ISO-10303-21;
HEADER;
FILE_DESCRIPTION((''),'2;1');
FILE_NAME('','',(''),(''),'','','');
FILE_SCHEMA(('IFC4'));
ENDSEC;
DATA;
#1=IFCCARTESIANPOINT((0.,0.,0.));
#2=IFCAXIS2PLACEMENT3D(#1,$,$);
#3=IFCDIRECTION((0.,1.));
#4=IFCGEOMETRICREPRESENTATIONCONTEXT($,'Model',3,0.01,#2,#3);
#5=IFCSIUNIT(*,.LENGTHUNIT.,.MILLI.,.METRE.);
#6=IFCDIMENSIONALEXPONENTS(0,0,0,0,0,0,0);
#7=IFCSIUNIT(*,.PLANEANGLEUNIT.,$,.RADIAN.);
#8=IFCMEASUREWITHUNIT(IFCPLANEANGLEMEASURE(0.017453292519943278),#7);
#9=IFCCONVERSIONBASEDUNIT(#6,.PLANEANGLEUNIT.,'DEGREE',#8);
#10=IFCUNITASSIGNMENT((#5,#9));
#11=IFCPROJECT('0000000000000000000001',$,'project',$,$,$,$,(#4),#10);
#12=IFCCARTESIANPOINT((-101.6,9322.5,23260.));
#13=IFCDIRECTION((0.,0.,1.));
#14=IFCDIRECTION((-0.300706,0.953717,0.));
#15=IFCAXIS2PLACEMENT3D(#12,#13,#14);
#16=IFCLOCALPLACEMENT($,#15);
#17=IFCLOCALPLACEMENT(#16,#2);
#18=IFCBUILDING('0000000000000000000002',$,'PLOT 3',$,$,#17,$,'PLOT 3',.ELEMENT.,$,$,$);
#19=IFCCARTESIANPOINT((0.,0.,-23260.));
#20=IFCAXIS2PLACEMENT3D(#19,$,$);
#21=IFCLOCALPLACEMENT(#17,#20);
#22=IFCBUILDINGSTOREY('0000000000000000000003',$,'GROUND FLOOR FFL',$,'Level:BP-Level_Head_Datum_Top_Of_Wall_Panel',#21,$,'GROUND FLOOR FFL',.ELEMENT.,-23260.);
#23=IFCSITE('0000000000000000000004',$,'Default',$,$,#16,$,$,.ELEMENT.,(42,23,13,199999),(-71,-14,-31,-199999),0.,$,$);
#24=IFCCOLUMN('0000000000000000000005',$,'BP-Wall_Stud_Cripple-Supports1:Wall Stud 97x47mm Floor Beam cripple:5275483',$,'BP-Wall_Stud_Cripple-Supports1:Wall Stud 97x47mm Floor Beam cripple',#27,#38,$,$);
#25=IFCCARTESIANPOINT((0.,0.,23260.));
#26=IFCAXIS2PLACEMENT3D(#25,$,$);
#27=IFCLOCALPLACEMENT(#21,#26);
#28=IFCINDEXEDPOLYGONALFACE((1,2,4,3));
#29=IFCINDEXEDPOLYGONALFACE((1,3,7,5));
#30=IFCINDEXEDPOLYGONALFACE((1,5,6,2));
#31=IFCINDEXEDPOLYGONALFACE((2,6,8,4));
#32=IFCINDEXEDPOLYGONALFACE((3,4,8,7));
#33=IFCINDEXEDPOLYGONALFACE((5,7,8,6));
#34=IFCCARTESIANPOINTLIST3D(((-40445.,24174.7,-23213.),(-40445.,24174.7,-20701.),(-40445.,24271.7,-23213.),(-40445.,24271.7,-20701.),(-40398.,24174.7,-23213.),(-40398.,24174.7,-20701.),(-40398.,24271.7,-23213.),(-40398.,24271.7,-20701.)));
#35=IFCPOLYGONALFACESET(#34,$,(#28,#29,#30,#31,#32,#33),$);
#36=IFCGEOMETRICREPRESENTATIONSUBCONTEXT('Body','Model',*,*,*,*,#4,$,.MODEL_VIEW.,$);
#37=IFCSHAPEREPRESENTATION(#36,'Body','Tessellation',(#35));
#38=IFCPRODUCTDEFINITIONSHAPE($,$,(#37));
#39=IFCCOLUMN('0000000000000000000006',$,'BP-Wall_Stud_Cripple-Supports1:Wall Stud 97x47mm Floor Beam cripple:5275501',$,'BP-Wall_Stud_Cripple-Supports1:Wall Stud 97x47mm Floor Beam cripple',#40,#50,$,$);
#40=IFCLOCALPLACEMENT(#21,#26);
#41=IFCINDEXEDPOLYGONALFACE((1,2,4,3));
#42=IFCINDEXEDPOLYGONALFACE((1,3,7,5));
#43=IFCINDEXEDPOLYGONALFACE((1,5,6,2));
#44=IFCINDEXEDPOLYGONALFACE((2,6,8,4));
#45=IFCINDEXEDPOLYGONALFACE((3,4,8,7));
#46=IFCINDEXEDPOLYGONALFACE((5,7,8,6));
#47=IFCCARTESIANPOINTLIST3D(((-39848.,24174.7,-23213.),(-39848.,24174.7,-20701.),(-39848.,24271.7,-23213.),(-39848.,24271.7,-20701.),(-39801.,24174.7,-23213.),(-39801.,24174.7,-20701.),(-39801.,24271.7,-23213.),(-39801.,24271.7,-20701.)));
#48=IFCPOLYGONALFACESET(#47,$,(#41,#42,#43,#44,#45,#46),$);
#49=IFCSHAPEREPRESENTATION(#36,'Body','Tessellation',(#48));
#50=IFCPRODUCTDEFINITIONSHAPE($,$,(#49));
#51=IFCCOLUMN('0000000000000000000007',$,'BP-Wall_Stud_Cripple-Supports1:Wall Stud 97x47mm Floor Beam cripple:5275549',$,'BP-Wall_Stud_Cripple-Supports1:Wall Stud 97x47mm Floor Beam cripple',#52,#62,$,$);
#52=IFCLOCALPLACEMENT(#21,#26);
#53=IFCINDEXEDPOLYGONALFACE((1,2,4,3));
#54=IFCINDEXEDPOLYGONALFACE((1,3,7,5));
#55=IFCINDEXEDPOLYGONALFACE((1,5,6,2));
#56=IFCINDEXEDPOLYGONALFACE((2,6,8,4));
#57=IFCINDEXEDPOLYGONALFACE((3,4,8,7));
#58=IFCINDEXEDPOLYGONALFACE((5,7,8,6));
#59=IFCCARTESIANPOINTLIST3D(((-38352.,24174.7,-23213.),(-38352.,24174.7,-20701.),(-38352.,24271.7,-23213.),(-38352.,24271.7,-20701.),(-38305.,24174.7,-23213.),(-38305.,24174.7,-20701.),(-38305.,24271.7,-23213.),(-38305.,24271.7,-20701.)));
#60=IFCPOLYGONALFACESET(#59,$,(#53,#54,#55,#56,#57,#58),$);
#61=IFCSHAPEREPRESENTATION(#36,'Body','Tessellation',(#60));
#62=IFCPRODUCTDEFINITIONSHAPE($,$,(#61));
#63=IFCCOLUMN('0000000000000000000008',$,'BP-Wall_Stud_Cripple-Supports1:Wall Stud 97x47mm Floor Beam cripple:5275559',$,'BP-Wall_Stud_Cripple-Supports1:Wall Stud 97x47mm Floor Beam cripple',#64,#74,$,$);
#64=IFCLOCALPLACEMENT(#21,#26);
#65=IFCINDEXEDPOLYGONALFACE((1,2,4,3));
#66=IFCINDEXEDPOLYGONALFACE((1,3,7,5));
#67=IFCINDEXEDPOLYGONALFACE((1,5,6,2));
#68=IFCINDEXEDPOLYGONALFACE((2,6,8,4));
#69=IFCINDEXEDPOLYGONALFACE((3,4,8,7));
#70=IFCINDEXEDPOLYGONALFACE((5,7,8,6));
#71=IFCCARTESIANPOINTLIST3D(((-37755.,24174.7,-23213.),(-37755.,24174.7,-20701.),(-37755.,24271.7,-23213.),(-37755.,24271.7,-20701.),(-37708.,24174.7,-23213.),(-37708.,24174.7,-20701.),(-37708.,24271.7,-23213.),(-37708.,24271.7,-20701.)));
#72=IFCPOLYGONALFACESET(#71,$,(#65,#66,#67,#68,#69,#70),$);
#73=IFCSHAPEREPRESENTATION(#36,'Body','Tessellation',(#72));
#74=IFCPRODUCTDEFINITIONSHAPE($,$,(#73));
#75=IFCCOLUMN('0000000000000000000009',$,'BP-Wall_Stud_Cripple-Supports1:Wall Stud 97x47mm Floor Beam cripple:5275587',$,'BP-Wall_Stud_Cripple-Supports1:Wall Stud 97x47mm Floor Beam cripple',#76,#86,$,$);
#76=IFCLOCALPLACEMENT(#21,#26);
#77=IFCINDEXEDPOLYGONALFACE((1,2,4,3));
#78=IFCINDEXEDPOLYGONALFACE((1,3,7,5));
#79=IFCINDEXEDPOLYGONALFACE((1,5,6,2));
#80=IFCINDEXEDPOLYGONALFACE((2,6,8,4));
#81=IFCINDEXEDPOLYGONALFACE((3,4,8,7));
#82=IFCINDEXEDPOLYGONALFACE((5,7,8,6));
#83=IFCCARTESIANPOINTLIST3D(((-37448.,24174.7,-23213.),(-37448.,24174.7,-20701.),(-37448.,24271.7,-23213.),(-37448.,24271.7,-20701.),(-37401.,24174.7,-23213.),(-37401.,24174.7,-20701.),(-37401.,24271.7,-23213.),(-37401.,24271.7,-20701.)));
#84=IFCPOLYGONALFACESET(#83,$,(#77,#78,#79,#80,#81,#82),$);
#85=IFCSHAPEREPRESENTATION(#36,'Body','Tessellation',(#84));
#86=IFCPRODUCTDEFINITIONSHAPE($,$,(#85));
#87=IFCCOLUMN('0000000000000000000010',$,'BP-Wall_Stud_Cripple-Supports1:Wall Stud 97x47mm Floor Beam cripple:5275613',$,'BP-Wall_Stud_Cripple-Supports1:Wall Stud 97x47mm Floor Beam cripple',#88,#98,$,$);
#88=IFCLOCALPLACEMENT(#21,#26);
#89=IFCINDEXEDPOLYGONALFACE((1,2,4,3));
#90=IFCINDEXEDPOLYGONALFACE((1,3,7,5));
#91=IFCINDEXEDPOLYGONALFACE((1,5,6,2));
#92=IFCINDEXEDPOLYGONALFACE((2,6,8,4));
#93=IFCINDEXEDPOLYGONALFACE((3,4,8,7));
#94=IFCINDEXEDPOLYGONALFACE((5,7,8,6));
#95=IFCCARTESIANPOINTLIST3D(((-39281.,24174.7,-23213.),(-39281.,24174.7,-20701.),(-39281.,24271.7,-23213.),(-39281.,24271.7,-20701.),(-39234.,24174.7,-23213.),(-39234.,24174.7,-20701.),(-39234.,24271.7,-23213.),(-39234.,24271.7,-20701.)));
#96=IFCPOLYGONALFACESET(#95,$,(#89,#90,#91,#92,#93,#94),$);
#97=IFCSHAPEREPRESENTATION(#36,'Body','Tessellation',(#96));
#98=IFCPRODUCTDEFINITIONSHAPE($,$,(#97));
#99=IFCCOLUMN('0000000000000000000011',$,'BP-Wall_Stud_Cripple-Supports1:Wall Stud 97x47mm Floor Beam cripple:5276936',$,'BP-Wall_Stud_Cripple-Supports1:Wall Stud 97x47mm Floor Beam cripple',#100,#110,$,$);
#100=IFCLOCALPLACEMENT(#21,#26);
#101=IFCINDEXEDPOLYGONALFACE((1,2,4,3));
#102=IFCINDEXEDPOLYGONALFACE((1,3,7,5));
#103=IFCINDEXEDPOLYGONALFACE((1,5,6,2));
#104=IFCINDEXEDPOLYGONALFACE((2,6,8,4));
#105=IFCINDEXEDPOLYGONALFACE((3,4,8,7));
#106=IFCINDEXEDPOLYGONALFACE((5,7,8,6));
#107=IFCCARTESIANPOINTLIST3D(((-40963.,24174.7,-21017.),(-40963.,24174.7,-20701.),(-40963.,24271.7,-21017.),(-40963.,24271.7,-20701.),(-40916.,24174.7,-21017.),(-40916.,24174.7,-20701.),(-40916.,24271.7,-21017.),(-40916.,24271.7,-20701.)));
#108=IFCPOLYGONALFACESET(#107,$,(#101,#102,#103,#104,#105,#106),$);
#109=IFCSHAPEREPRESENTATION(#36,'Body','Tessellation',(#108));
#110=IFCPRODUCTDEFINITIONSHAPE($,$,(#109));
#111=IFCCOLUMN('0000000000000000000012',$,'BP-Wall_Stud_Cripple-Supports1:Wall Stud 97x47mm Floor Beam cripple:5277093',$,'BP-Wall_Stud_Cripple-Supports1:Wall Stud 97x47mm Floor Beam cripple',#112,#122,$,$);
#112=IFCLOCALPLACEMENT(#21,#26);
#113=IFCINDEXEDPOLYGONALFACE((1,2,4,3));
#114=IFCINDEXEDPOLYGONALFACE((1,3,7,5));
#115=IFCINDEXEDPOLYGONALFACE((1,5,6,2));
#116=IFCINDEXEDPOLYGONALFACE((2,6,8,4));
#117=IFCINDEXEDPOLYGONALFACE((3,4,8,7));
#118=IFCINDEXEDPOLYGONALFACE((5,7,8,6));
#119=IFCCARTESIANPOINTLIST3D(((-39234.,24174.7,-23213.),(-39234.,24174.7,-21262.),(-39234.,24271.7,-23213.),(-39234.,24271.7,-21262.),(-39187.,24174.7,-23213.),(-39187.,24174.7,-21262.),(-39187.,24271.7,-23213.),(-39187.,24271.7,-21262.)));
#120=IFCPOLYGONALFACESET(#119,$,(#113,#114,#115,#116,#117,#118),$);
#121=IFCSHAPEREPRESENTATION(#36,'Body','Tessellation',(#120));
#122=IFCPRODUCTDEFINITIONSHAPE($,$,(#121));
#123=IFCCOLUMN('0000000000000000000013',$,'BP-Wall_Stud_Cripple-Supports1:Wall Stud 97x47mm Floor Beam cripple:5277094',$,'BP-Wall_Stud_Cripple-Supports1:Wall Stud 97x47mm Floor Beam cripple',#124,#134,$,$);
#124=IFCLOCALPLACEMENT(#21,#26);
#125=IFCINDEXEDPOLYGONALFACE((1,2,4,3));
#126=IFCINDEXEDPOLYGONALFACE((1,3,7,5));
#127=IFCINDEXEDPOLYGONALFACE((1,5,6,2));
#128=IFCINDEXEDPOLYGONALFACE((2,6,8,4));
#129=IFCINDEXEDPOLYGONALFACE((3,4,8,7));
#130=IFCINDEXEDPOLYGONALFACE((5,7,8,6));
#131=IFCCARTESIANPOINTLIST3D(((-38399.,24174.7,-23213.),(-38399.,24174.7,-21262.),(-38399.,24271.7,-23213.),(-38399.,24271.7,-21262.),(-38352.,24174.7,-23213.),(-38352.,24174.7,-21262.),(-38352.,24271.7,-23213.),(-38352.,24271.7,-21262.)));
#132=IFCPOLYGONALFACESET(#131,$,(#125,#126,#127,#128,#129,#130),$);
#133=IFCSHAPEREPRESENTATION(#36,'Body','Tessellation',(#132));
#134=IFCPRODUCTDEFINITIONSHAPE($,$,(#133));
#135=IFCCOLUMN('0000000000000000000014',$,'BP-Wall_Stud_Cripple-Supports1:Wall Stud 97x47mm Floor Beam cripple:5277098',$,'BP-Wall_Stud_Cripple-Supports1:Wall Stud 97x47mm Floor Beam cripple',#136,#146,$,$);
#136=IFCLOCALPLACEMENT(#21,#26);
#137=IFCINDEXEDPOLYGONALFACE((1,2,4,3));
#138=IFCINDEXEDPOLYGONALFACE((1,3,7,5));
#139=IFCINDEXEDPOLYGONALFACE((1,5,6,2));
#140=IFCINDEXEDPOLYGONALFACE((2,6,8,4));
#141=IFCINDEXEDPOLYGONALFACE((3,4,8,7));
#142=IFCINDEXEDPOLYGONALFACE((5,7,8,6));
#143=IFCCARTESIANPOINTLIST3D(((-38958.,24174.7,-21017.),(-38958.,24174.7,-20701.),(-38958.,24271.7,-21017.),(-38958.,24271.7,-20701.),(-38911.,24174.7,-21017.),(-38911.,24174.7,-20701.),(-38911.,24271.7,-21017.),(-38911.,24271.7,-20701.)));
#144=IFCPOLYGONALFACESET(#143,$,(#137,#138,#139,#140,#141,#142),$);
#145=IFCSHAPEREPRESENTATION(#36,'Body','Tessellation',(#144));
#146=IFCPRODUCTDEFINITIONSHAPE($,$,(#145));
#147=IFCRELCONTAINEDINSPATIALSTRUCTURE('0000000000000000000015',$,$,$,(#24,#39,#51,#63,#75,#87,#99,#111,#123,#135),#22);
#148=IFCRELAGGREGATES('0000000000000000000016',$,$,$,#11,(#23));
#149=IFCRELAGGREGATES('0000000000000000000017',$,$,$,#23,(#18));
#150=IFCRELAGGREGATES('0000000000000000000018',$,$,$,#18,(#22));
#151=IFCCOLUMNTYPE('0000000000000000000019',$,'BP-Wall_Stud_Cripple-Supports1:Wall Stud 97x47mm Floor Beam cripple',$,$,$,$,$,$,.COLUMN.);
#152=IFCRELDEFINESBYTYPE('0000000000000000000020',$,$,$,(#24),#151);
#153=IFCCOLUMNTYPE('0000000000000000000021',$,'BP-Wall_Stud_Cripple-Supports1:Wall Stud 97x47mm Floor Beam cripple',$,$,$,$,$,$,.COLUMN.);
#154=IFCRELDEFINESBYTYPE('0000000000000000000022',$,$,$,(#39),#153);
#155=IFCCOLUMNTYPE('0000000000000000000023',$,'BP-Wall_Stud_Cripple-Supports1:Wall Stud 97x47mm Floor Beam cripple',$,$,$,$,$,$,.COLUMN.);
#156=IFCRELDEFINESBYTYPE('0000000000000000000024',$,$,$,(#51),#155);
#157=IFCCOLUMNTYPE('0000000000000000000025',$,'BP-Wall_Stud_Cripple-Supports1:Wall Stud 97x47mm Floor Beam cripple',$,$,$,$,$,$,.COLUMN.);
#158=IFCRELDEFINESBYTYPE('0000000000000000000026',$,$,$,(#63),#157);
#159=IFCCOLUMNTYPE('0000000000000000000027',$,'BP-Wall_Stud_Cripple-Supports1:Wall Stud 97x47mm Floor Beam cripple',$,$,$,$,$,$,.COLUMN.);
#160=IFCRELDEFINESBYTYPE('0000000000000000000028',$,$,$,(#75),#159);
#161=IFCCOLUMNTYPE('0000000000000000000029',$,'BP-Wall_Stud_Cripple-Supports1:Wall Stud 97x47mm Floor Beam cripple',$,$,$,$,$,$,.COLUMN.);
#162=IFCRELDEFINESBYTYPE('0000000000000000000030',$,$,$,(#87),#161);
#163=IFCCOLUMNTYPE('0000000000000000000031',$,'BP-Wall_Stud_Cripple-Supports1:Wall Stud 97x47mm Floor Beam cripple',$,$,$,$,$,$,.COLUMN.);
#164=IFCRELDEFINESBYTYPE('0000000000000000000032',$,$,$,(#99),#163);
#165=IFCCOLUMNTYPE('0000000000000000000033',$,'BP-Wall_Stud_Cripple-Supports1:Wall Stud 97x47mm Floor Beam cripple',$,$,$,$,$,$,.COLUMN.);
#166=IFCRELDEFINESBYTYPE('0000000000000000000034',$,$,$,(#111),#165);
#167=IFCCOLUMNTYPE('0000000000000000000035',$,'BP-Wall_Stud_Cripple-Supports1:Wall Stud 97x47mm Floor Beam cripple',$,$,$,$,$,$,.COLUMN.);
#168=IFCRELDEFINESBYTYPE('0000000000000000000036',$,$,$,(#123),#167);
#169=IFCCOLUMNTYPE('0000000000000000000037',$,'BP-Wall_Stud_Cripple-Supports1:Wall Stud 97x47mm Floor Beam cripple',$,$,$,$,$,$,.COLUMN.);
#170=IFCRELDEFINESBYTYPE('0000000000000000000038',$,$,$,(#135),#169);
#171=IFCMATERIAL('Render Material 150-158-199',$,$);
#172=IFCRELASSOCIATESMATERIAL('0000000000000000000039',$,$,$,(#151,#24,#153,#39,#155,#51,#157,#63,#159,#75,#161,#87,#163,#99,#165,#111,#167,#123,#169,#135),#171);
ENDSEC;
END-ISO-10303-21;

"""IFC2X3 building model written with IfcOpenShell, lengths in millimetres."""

from ifc_helpers import new_model, entity, si_unit, converted_unit, direction, frame, frame_2d, origin, place, context, subcontext, project, spatial, rectangle, extrude, source, transform, mapped, material, type_object, type_shapes, element, save


model = new_model("IFC2X3")

# Units and contexts
model_context = context("Model", 3, precision=0.01, world=origin(), true_north=direction((0.0, 1.0)))
body_context = subcontext(model_context, "Body", "Model", "MODEL_VIEW")
ifc_project = project(units=[si_unit("LENGTHUNIT", "METRE", prefix="MILLI"), converted_unit("PLANEANGLEUNIT", "DEGREE", entity("IfcPlaneAngleMeasure", 0.017453292519943278), si_unit("PLANEANGLEUNIT", "RADIAN"), dimensions=[0, 0, 0, 0, 0, 0, 0])], contexts=[model_context])

# Site, building, storey
site_placement = place(None, frame((-101.6, 9322.5, 23260.0), z_axis=(0.0, 0.0, 1.0), x_axis=(-0.300706, 0.953717, 0.0)))
site = spatial("IfcSite", under=ifc_project, at=site_placement, Name="Default", CompositionType="ELEMENT", RefLatitude=(42, 23, 13, 199999), RefLongitude=(-71, -14, -31, -199999), RefElevation=0.0)
building_placement = place(site_placement, origin())
building = spatial("IfcBuilding", under=site, at=building_placement, Name="PLOT 3", LongName="PLOT 3", CompositionType="ELEMENT")
storey_placement = place(building_placement, frame((0.0, 0.0, -23260.0)))
storey = spatial("IfcBuildingStorey", under=building, at=storey_placement, Name="GROUND FLOOR FFL", ObjectType="Level:BP-Level_Head_Datum_Top_Of_Wall_Panel", LongName="GROUND FLOOR FFL", CompositionType="ELEMENT", Elevation=-23260.0)

# Columns
ifc_material_1 = material(Name="Render Material 150-158-199")
column_type_1 = type_object("IfcColumnType", Name="BP-Wall_Stud_Cripple-Supports1:Wall Stud 97x47mm Floor Beam cripple", PredefinedType="COLUMN", material=ifc_material_1)
shared_shape_1 = source(origin(), body_context, "Body", "SweptSolid", [
    extrude(rectangle(XDim=97.0, YDim=47.0, at=frame_2d((0.0, 0.0), x_axis=(1.0, 0.0))), frame((-40421.5, 24223.2, -23213.0), z_axis=(0.0, 0.0, 1.0), x_axis=(0.0, -1.0, 0.0)), (0.0, 0.0, 1.0), 2512.0),
])
type_shapes(column_type_1, [shared_shape_1])
column_1_placement = place(storey_placement, frame((0.0, 0.0, 23260.0)))
element("IfcColumn", 1, at=column_1_placement, inside=storey, type_object=column_type_1, material=ifc_material_1, Name="BP-Wall_Stud_Cripple-Supports1:Wall Stud 97x47mm Floor Beam cripple:5275483", ObjectType="BP-Wall_Stud_Cripple-Supports1:Wall Stud 97x47mm Floor Beam cripple", context=body_context, shape_type="MappedRepresentation", body=[
    mapped(shared_shape_1, transform((0.0, 0.0, 0.0), scale=1.0)),
])
column_type_2 = type_object("IfcColumnType", Name="BP-Wall_Stud_Cripple-Supports1:Wall Stud 97x47mm Floor Beam cripple", PredefinedType="COLUMN", material=ifc_material_1)
shared_shape_2 = source(origin(), body_context, "Body", "SweptSolid", [
    extrude(rectangle(XDim=97.0, YDim=47.0, at=frame_2d((0.0, 0.0), x_axis=(1.0, 0.0))), frame((-39824.5, 24223.2, -23213.0), z_axis=(0.0, 0.0, 1.0), x_axis=(0.0, -1.0, 0.0)), (0.0, 0.0, 1.0), 2512.0),
])
type_shapes(column_type_2, [shared_shape_2])
column_2_placement = place(storey_placement, frame((0.0, 0.0, 23260.0)))
element("IfcColumn", 2, at=column_2_placement, inside=storey, type_object=column_type_2, material=ifc_material_1, Name="BP-Wall_Stud_Cripple-Supports1:Wall Stud 97x47mm Floor Beam cripple:5275501", ObjectType="BP-Wall_Stud_Cripple-Supports1:Wall Stud 97x47mm Floor Beam cripple", context=body_context, shape_type="MappedRepresentation", body=[
    mapped(shared_shape_2, transform((0.0, 0.0, 0.0), scale=1.0)),
])
column_type_3 = type_object("IfcColumnType", Name="BP-Wall_Stud_Cripple-Supports1:Wall Stud 97x47mm Floor Beam cripple", PredefinedType="COLUMN", material=ifc_material_1)
shared_shape_3 = source(origin(), body_context, "Body", "SweptSolid", [
    extrude(rectangle(XDim=97.0, YDim=47.0, at=frame_2d((0.0, 0.0), x_axis=(1.0, 0.0))), frame((-38328.5, 24223.2, -23213.0), z_axis=(0.0, 0.0, 1.0), x_axis=(0.0, -1.0, 0.0)), (0.0, 0.0, 1.0), 2512.0),
])
type_shapes(column_type_3, [shared_shape_3])
column_3_placement = place(storey_placement, frame((0.0, 0.0, 23260.0)))
element("IfcColumn", 3, at=column_3_placement, inside=storey, type_object=column_type_3, material=ifc_material_1, Name="BP-Wall_Stud_Cripple-Supports1:Wall Stud 97x47mm Floor Beam cripple:5275549", ObjectType="BP-Wall_Stud_Cripple-Supports1:Wall Stud 97x47mm Floor Beam cripple", context=body_context, shape_type="MappedRepresentation", body=[
    mapped(shared_shape_3, transform((0.0, 0.0, 0.0), scale=1.0)),
])
column_type_4 = type_object("IfcColumnType", Name="BP-Wall_Stud_Cripple-Supports1:Wall Stud 97x47mm Floor Beam cripple", PredefinedType="COLUMN", material=ifc_material_1)
shared_shape_4 = source(origin(), body_context, "Body", "SweptSolid", [
    extrude(rectangle(XDim=97.0, YDim=47.0, at=frame_2d((0.0, 0.0), x_axis=(1.0, 0.0))), frame((-37731.5, 24223.2, -23213.0), z_axis=(0.0, 0.0, 1.0), x_axis=(0.0, -1.0, 0.0)), (0.0, 0.0, 1.0), 2512.0),
])
type_shapes(column_type_4, [shared_shape_4])
column_4_placement = place(storey_placement, frame((0.0, 0.0, 23260.0)))
element("IfcColumn", 4, at=column_4_placement, inside=storey, type_object=column_type_4, material=ifc_material_1, Name="BP-Wall_Stud_Cripple-Supports1:Wall Stud 97x47mm Floor Beam cripple:5275559", ObjectType="BP-Wall_Stud_Cripple-Supports1:Wall Stud 97x47mm Floor Beam cripple", context=body_context, shape_type="MappedRepresentation", body=[
    mapped(shared_shape_4, transform((0.0, 0.0, 0.0), scale=1.0)),
])
column_type_5 = type_object("IfcColumnType", Name="BP-Wall_Stud_Cripple-Supports1:Wall Stud 97x47mm Floor Beam cripple", PredefinedType="COLUMN", material=ifc_material_1)
shared_shape_5 = source(origin(), body_context, "Body", "SweptSolid", [
    extrude(rectangle(XDim=97.0, YDim=47.0, at=frame_2d((0.0, 0.0), x_axis=(1.0, 0.0))), frame((-37424.5, 24223.2, -23213.0), z_axis=(0.0, 0.0, 1.0), x_axis=(0.0, -1.0, 0.0)), (0.0, 0.0, 1.0), 2512.0),
])
type_shapes(column_type_5, [shared_shape_5])
column_5_placement = place(storey_placement, frame((0.0, 0.0, 23260.0)))
element("IfcColumn", 5, at=column_5_placement, inside=storey, type_object=column_type_5, material=ifc_material_1, Name="BP-Wall_Stud_Cripple-Supports1:Wall Stud 97x47mm Floor Beam cripple:5275587", ObjectType="BP-Wall_Stud_Cripple-Supports1:Wall Stud 97x47mm Floor Beam cripple", context=body_context, shape_type="MappedRepresentation", body=[
    mapped(shared_shape_5, transform((0.0, 0.0, 0.0), scale=1.0)),
])
column_type_6 = type_object("IfcColumnType", Name="BP-Wall_Stud_Cripple-Supports1:Wall Stud 97x47mm Floor Beam cripple", PredefinedType="COLUMN", material=ifc_material_1)
shared_shape_6 = source(origin(), body_context, "Body", "SweptSolid", [
    extrude(rectangle(XDim=97.0, YDim=47.0, at=frame_2d((0.0, 0.0), x_axis=(1.0, 0.0))), frame((-39257.5, 24223.2, -23213.0), z_axis=(0.0, 0.0, 1.0), x_axis=(0.0, -1.0, 0.0)), (0.0, 0.0, 1.0), 2512.0),
])
type_shapes(column_type_6, [shared_shape_6])
column_6_placement = place(storey_placement, frame((0.0, 0.0, 23260.0)))
element("IfcColumn", 6, at=column_6_placement, inside=storey, type_object=column_type_6, material=ifc_material_1, Name="BP-Wall_Stud_Cripple-Supports1:Wall Stud 97x47mm Floor Beam cripple:5275613", ObjectType="BP-Wall_Stud_Cripple-Supports1:Wall Stud 97x47mm Floor Beam cripple", context=body_context, shape_type="MappedRepresentation", body=[
    mapped(shared_shape_6, transform((0.0, 0.0, 0.0), scale=1.0)),
])
column_type_7 = type_object("IfcColumnType", Name="BP-Wall_Stud_Cripple-Supports1:Wall Stud 97x47mm Floor Beam cripple", PredefinedType="COLUMN", material=ifc_material_1)
shared_shape_7 = source(origin(), body_context, "Body", "SweptSolid", [
    extrude(rectangle(XDim=97.0, YDim=47.0, at=frame_2d((0.0, 0.0), x_axis=(1.0, 0.0))), frame((-40939.5, 24223.2, -21017.0), z_axis=(0.0, 0.0, 1.0), x_axis=(0.0, -1.0, 0.0)), (0.0, 0.0, 1.0), 316.0),
])
type_shapes(column_type_7, [shared_shape_7])
column_7_placement = place(storey_placement, frame((0.0, 0.0, 23260.0)))
element("IfcColumn", 7, at=column_7_placement, inside=storey, type_object=column_type_7, material=ifc_material_1, Name="BP-Wall_Stud_Cripple-Supports1:Wall Stud 97x47mm Floor Beam cripple:5276936", ObjectType="BP-Wall_Stud_Cripple-Supports1:Wall Stud 97x47mm Floor Beam cripple", context=body_context, shape_type="MappedRepresentation", body=[
    mapped(shared_shape_7, transform((0.0, 0.0, 0.0), scale=1.0)),
])
column_type_8 = type_object("IfcColumnType", Name="BP-Wall_Stud_Cripple-Supports1:Wall Stud 97x47mm Floor Beam cripple", PredefinedType="COLUMN", material=ifc_material_1)
shared_shape_8 = source(origin(), body_context, "Body", "SweptSolid", [
    extrude(rectangle(XDim=97.0, YDim=47.0, at=frame_2d((0.0, 0.0), x_axis=(1.0, 0.0))), frame((-39210.5, 24223.2, -23213.0), z_axis=(0.0, 0.0, 1.0), x_axis=(0.0, -1.0, 0.0)), (0.0, 0.0, 1.0), 1951.0),
])
type_shapes(column_type_8, [shared_shape_8])
column_8_placement = place(storey_placement, frame((0.0, 0.0, 23260.0)))
element("IfcColumn", 8, at=column_8_placement, inside=storey, type_object=column_type_8, material=ifc_material_1, Name="BP-Wall_Stud_Cripple-Supports1:Wall Stud 97x47mm Floor Beam cripple:5277093", ObjectType="BP-Wall_Stud_Cripple-Supports1:Wall Stud 97x47mm Floor Beam cripple", context=body_context, shape_type="MappedRepresentation", body=[
    mapped(shared_shape_8, transform((0.0, 0.0, 0.0), scale=1.0)),
])
column_type_9 = type_object("IfcColumnType", Name="BP-Wall_Stud_Cripple-Supports1:Wall Stud 97x47mm Floor Beam cripple", PredefinedType="COLUMN", material=ifc_material_1)
shared_shape_9 = source(origin(), body_context, "Body", "SweptSolid", [
    extrude(rectangle(XDim=97.0, YDim=47.0, at=frame_2d((0.0, 0.0), x_axis=(1.0, 0.0))), frame((-38375.5, 24223.2, -23213.0), z_axis=(0.0, 0.0, 1.0), x_axis=(0.0, -1.0, 0.0)), (0.0, 0.0, 1.0), 1951.0),
])
type_shapes(column_type_9, [shared_shape_9])
column_9_placement = place(storey_placement, frame((0.0, 0.0, 23260.0)))
element("IfcColumn", 9, at=column_9_placement, inside=storey, type_object=column_type_9, material=ifc_material_1, Name="BP-Wall_Stud_Cripple-Supports1:Wall Stud 97x47mm Floor Beam cripple:5277094", ObjectType="BP-Wall_Stud_Cripple-Supports1:Wall Stud 97x47mm Floor Beam cripple", context=body_context, shape_type="MappedRepresentation", body=[
    mapped(shared_shape_9, transform((0.0, 0.0, 0.0), scale=1.0)),
])
column_type_10 = type_object("IfcColumnType", Name="BP-Wall_Stud_Cripple-Supports1:Wall Stud 97x47mm Floor Beam cripple", PredefinedType="COLUMN", material=ifc_material_1)
shared_shape_10 = source(origin(), body_context, "Body", "SweptSolid", [
    extrude(rectangle(XDim=97.0, YDim=47.0, at=frame_2d((0.0, 0.0), x_axis=(1.0, 0.0))), frame((-38934.5, 24223.2, -21017.0), z_axis=(0.0, 0.0, 1.0), x_axis=(0.0, -1.0, 0.0)), (0.0, 0.0, 1.0), 316.0),
])
type_shapes(column_type_10, [shared_shape_10])
column_10_placement = place(storey_placement, frame((0.0, 0.0, 23260.0)))
element("IfcColumn", 10, at=column_10_placement, inside=storey, type_object=column_type_10, material=ifc_material_1, Name="BP-Wall_Stud_Cripple-Supports1:Wall Stud 97x47mm Floor Beam cripple:5277098", ObjectType="BP-Wall_Stud_Cripple-Supports1:Wall Stud 97x47mm Floor Beam cripple", context=body_context, shape_type="MappedRepresentation", body=[
    mapped(shared_shape_10, transform((0.0, 0.0, 0.0), scale=1.0)),
])

save(model, "model.ifc")
